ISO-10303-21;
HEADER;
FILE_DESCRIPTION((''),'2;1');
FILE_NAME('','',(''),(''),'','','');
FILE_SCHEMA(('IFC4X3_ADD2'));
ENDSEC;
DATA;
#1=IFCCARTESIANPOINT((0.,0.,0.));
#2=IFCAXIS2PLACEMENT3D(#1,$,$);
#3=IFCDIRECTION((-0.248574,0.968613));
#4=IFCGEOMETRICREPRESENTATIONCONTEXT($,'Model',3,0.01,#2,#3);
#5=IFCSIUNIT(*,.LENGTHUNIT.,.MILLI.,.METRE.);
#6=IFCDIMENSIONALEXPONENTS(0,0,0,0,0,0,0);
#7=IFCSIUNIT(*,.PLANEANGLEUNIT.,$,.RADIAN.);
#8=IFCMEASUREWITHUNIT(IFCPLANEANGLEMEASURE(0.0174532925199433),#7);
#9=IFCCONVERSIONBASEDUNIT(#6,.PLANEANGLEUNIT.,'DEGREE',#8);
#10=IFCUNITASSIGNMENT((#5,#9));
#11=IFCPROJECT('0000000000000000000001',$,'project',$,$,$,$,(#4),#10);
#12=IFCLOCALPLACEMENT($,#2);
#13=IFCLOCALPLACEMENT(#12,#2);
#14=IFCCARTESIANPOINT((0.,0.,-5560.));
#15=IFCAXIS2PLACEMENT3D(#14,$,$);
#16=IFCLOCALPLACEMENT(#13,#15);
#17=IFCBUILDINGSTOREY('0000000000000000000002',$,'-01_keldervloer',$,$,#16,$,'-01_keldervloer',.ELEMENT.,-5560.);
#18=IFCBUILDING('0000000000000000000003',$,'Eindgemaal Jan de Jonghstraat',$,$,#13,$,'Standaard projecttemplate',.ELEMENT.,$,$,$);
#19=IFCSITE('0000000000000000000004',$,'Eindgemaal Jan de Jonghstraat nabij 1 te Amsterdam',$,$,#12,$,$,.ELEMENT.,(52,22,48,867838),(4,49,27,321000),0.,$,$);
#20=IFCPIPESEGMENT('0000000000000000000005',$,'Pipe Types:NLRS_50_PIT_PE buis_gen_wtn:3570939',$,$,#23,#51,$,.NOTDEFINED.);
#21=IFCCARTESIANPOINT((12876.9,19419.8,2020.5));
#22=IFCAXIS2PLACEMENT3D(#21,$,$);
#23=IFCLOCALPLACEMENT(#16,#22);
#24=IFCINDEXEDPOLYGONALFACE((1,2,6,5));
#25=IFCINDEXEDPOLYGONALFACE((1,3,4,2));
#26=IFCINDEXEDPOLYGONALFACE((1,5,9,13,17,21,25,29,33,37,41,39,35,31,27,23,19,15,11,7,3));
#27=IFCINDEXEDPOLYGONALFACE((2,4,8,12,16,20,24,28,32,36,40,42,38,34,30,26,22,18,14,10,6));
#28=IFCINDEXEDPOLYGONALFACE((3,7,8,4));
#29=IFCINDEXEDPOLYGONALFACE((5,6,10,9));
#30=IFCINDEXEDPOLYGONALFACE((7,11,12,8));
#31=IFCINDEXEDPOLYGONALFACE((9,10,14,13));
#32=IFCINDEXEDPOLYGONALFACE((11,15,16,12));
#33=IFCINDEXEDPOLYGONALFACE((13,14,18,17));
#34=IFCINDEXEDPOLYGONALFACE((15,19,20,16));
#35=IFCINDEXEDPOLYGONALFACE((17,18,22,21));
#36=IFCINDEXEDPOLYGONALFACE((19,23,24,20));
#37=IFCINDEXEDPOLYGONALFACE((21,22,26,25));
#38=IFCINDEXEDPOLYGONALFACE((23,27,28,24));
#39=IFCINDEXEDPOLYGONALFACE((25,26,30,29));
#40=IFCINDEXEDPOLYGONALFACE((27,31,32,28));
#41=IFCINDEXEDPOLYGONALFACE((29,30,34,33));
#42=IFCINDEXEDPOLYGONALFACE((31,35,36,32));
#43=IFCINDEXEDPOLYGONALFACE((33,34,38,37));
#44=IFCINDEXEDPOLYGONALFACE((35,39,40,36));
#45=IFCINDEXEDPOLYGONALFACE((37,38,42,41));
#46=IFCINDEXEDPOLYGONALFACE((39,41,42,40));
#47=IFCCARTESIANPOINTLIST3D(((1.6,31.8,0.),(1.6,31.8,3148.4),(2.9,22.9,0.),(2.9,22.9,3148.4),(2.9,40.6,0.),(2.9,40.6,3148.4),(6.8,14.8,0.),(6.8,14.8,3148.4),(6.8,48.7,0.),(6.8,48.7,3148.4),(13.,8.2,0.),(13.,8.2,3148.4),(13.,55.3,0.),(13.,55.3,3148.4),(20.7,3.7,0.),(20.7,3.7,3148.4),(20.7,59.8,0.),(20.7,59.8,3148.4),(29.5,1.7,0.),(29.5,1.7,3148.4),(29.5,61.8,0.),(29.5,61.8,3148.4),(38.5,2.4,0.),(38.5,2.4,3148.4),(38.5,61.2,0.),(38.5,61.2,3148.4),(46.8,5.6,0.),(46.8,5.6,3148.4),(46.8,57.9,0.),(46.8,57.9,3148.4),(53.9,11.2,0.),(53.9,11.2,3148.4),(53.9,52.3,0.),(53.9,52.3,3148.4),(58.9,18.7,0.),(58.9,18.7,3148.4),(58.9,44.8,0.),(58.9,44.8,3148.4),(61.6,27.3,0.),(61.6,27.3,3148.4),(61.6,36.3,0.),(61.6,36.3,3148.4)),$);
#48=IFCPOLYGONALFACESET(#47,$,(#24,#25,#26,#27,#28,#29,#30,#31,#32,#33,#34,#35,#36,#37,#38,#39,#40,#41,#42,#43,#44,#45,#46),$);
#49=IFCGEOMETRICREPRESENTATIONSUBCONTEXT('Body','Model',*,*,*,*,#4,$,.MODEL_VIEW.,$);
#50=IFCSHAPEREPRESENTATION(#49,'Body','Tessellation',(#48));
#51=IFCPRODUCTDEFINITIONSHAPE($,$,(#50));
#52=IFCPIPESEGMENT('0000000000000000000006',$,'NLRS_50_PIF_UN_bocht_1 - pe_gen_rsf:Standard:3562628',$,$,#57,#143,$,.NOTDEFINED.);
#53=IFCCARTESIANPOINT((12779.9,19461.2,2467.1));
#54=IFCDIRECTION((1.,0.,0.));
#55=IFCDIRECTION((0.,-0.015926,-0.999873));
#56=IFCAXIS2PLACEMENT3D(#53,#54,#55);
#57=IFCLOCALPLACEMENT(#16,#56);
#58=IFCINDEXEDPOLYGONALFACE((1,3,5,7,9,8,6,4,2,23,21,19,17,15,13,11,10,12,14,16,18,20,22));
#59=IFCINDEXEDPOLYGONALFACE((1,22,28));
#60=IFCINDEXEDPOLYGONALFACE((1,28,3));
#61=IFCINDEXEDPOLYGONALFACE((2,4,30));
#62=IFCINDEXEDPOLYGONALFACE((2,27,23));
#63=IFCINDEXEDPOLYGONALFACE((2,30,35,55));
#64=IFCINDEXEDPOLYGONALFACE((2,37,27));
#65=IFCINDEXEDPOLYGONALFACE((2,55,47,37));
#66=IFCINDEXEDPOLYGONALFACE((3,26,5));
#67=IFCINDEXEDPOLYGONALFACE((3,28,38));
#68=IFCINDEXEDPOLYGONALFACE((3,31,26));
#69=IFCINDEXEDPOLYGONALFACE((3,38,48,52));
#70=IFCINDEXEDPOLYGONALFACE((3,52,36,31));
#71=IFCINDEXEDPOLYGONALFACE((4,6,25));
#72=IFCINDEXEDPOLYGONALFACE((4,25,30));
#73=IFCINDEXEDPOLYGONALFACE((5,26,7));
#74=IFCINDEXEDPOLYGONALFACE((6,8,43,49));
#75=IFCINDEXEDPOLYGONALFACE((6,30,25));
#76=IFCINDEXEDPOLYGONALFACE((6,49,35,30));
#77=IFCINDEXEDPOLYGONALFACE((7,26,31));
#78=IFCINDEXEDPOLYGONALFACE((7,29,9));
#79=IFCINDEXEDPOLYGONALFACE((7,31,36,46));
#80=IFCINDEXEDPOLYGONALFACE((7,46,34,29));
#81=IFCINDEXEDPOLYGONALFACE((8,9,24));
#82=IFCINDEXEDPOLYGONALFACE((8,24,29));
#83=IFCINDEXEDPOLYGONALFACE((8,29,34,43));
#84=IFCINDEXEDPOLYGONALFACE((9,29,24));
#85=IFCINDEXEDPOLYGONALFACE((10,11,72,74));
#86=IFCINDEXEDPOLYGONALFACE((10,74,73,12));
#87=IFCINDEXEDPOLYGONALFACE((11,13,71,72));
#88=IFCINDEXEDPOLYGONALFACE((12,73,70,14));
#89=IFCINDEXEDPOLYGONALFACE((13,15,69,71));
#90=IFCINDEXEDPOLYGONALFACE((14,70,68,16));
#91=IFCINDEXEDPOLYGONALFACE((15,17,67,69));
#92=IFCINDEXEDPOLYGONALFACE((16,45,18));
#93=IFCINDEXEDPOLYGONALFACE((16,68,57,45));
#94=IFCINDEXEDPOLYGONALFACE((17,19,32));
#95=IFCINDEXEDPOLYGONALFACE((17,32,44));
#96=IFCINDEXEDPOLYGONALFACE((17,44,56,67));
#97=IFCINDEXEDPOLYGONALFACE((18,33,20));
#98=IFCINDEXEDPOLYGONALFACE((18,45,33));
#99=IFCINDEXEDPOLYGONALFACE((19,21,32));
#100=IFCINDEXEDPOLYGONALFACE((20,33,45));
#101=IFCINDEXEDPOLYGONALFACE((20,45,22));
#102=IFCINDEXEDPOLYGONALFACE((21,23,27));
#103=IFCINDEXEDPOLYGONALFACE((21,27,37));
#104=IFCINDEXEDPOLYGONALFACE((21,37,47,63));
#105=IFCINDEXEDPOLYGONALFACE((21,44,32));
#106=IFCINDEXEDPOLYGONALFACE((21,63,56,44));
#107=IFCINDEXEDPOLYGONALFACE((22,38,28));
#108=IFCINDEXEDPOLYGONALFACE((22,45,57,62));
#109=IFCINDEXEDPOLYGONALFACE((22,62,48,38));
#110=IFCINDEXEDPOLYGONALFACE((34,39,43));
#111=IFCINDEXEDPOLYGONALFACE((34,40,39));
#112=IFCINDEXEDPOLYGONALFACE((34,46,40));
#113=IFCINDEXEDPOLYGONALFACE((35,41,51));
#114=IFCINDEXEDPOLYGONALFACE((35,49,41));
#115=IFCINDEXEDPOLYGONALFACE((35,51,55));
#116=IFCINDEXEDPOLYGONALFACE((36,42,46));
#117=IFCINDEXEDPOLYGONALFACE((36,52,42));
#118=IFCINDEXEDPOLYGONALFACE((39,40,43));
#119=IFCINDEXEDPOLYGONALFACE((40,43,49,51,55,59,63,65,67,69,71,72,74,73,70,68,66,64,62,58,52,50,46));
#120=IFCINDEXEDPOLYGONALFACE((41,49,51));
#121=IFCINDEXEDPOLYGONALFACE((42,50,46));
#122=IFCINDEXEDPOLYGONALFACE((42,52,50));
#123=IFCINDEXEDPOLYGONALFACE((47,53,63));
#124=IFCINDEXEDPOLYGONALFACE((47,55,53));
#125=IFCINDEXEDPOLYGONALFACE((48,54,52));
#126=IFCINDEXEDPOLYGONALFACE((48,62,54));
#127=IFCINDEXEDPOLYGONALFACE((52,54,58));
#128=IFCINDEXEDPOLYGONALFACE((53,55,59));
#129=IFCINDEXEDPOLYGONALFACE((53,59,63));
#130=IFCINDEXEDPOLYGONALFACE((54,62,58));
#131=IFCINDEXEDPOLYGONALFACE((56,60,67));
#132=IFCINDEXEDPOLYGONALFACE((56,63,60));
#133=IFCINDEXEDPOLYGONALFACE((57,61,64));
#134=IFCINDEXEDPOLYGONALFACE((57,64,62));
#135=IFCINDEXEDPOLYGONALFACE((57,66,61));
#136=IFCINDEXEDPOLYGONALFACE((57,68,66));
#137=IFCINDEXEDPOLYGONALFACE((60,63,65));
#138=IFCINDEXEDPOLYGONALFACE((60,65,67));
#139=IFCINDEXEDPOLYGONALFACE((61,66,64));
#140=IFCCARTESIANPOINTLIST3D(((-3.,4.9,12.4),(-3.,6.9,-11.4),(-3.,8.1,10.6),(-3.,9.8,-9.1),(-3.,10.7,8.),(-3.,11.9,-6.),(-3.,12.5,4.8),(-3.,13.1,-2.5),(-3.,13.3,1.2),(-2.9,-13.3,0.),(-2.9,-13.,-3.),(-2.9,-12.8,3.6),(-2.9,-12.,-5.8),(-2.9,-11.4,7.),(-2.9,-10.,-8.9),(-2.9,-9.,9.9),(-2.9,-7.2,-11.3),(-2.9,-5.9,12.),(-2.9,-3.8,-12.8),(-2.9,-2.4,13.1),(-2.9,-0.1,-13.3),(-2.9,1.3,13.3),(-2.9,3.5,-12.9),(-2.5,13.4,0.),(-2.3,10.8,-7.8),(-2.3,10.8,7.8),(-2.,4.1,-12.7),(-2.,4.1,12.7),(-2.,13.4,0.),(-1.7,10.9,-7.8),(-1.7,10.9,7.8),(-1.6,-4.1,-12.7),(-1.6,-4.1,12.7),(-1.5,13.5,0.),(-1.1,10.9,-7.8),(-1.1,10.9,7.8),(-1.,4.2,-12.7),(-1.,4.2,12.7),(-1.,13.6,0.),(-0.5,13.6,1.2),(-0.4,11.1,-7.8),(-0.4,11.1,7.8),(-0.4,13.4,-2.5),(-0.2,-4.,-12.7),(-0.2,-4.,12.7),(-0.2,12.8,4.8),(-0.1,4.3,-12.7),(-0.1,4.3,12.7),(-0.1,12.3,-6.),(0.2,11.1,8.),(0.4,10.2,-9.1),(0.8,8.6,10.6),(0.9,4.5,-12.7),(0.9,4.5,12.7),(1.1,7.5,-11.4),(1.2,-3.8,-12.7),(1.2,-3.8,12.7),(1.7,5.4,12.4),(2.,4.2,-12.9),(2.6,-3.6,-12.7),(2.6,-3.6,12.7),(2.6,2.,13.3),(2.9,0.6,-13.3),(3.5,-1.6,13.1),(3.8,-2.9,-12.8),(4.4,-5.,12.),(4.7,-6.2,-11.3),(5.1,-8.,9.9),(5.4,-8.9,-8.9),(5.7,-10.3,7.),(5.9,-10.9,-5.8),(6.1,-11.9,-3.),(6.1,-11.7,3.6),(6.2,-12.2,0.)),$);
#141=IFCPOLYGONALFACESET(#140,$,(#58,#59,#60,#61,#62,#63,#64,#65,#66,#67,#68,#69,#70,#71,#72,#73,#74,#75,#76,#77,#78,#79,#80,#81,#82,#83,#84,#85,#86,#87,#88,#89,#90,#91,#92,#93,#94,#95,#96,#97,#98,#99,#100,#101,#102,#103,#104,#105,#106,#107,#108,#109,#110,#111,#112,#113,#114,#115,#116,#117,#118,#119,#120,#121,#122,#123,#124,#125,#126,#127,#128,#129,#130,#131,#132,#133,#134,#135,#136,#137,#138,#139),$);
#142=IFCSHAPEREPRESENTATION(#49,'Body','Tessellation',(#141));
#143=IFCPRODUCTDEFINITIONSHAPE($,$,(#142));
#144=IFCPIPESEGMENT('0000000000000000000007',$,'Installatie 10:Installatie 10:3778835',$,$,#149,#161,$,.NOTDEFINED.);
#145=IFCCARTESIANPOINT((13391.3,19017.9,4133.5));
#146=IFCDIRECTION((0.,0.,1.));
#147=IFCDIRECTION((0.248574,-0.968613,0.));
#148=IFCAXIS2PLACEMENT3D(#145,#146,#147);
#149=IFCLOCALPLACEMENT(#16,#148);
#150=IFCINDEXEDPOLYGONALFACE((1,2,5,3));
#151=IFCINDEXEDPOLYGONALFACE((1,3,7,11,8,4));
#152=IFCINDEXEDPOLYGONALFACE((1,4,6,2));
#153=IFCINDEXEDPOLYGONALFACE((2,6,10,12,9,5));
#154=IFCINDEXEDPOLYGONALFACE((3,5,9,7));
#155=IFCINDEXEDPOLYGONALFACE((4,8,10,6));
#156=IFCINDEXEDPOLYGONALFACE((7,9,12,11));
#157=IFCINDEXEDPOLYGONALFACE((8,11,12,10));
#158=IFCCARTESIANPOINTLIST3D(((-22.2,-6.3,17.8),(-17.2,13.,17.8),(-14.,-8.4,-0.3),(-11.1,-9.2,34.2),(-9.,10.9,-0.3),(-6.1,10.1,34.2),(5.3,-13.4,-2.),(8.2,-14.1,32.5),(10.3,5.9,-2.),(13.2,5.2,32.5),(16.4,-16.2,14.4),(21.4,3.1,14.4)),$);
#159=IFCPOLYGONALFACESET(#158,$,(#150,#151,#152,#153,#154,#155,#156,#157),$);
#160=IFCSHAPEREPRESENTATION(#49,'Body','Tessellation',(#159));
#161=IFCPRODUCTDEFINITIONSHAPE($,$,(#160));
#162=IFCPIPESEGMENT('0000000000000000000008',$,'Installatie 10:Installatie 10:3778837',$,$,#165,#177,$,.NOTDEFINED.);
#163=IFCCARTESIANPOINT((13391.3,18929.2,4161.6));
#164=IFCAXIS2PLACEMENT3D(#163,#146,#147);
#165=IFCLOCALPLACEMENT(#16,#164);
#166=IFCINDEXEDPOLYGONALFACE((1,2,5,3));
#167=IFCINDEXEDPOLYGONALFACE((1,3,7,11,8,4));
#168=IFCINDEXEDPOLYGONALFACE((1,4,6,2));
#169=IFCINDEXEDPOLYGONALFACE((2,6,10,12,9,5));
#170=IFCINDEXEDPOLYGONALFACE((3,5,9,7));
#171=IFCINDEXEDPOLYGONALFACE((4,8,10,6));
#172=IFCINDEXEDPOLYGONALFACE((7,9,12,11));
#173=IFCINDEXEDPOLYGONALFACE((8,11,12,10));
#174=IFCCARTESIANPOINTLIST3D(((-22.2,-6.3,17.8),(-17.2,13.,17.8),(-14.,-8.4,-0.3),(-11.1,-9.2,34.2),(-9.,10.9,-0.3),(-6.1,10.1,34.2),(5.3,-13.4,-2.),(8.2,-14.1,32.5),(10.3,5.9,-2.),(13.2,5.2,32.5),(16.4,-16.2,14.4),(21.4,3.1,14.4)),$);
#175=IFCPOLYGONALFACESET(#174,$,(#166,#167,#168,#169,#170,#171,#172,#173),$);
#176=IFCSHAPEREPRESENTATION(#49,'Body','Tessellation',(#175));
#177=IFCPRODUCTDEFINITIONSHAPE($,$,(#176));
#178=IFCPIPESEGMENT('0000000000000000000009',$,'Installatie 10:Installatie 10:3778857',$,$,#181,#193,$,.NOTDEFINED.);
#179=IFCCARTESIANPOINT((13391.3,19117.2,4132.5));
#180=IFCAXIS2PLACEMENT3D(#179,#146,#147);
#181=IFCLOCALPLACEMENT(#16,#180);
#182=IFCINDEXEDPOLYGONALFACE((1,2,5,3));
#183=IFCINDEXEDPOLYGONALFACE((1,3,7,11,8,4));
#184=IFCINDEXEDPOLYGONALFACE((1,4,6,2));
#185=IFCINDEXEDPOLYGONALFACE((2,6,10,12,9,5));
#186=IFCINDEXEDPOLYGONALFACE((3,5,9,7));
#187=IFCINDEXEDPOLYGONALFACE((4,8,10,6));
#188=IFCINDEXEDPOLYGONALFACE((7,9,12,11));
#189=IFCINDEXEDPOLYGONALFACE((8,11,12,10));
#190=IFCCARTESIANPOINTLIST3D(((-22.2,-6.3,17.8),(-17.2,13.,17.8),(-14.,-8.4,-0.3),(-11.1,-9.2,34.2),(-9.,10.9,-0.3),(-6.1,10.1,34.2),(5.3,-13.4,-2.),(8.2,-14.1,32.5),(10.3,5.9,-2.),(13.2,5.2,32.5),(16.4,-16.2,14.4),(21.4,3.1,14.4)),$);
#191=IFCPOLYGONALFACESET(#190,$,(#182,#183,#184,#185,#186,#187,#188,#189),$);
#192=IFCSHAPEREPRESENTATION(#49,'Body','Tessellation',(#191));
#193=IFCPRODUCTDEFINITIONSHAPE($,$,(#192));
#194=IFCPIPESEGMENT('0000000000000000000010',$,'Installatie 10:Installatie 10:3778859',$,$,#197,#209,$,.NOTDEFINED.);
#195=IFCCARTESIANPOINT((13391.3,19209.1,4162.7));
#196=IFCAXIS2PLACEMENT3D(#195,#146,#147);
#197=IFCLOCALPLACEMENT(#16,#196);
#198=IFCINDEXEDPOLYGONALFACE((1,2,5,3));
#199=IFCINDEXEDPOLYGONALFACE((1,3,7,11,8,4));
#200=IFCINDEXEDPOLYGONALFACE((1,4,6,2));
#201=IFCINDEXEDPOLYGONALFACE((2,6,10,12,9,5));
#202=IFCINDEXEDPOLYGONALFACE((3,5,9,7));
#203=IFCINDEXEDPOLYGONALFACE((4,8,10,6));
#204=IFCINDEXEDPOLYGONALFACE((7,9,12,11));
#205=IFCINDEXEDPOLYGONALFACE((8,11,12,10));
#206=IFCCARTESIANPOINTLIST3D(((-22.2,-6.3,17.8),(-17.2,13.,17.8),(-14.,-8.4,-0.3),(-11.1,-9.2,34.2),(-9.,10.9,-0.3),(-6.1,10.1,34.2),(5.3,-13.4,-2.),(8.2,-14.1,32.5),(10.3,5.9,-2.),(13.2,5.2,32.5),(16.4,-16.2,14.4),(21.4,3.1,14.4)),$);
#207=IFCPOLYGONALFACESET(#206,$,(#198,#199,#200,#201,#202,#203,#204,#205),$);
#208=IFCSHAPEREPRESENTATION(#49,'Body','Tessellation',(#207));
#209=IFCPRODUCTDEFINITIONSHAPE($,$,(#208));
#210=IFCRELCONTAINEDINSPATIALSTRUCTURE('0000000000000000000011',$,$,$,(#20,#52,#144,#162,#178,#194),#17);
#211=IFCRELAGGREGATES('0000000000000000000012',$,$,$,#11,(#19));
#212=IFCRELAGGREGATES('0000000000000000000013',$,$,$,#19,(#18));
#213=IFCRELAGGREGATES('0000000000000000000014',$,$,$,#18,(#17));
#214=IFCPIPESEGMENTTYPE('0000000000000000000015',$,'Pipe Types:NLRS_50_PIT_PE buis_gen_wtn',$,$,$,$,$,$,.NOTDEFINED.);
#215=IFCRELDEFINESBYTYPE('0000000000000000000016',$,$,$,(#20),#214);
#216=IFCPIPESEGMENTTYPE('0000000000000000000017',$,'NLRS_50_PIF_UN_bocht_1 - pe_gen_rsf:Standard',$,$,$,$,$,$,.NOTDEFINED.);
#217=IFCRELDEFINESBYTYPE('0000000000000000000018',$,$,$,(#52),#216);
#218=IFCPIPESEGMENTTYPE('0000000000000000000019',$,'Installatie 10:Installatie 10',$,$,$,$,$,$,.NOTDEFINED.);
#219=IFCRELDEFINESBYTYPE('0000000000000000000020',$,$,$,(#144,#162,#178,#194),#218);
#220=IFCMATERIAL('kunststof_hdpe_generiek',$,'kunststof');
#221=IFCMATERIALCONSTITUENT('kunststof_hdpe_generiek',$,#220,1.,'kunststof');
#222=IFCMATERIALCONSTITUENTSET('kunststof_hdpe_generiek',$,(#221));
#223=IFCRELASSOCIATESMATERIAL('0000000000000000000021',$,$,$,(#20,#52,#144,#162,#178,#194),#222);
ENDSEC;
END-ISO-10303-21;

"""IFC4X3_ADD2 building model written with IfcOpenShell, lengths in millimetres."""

from ifc_helpers import new_model, entity, si_unit, converted_unit, direction, frame, frame_2d, origin, place, context, subcontext, project, spatial, polyline, circle, outline, extrude, source, transform, mapped, material, constituent, constituent_set, type_object, type_shapes, element, save


model = new_model("IFC4X3_ADD2")

# Units and contexts
model_context = context("Model", 3, precision=0.01, world=origin(), true_north=direction((-0.248574, 0.968613)))
body_context = subcontext(model_context, "Body", "Model", "MODEL_VIEW")
ifc_project = project(units=[si_unit("LENGTHUNIT", "METRE", prefix="MILLI"), converted_unit("PLANEANGLEUNIT", "DEGREE", entity("IfcPlaneAngleMeasure", 0.0174532925199433), si_unit("PLANEANGLEUNIT", "RADIAN"), dimensions=[0, 0, 0, 0, 0, 0, 0])], contexts=[model_context])

# Site, building, storey
site_placement = place(None, origin())
site = spatial("IfcSite", under=ifc_project, at=site_placement, Name="Eindgemaal Jan de Jonghstraat nabij 1 te Amsterdam", CompositionType="ELEMENT", RefLatitude=(52, 22, 48, 867838), RefLongitude=(4, 49, 27, 321000), RefElevation=0.0)
building_placement = place(site_placement, origin())
building = spatial("IfcBuilding", under=site, at=building_placement, Name="Eindgemaal Jan de Jonghstraat", LongName="Standaard projecttemplate", CompositionType="ELEMENT")
storey_placement = place(building_placement, frame((0.0, 0.0, -5560.0)))
storey = spatial("IfcBuildingStorey", under=building, at=storey_placement, Name="-01_keldervloer", LongName="-01_keldervloer", CompositionType="ELEMENT", Elevation=-5560.0)

# Pipe segments
ifc_material_1 = material(Name="kunststof_hdpe_generiek", Category="kunststof")
ifc_constituent_1 = constituent(ifc_material_1, Name="kunststof_hdpe_generiek", Category="kunststof", fraction=1.0)
ifc_constituent_set_1 = constituent_set(constituents=[ifc_constituent_1], Name="kunststof_hdpe_generiek")
pipe_segment_type_1 = type_object("IfcPipeSegmentType", Name="Pipe Types:NLRS_50_PIT_PE buis_gen_wtn", PredefinedType="NOTDEFINED")
pipe_segment_1_placement = place(storey_placement, frame((12876.9, 19419.8, 2020.5)))
element("IfcPipeSegment", 1, at=pipe_segment_1_placement, inside=storey, type_object=pipe_segment_type_1, material=ifc_constituent_set_1, Name="Pipe Types:NLRS_50_PIT_PE buis_gen_wtn:3570939", PredefinedType="NOTDEFINED", context=body_context, shape_type="SweptSolid", body=[
    extrude(circle(Radius=30.2, at=frame_2d((0.0, 0.0), x_axis=(1.0, 0.0))), frame((31.8, 31.8, 0.0), z_axis=(0.0, 0.0, 1.0), x_axis=(-1.0, 0.0, 0.0)), (0.0, 0.0, 1.0), 3148.4),
])
pipe_segment_type_2 = type_object("IfcPipeSegmentType", Name="NLRS_50_PIF_UN_bocht_1 - pe_gen_rsf:Standard", PredefinedType="NOTDEFINED")
trimmed_curve = entity("IfcTrimmedCurve", entity("IfcCircle", entity("IfcAxis2Placement2D", entity("IfcCartesianPoint", [-10.0, 0.0]), entity("IfcDirection", [0.968378, 0.249489])), 10.0), [entity("IfcParameterValue", 345.552699)], [entity("IfcParameterValue", 0.0)], True, "PARAMETER")
shared_shape_1 = source(origin(), body_context, "Body", "AdvancedSweptSolid", [
    entity("IfcSurfaceCurveSweptAreaSolid", entity("IfcCircleProfileDef", "AREA", None, entity("IfcAxis2Placement2D", entity("IfcCartesianPoint", [13.3, 0.0]), entity("IfcDirection", [1.0, 0.0])), 13.3), entity("IfcAxis2Placement3D", entity("IfcCartesianPoint", [-0.5, 13.7, 0.0]), entity("IfcDirection", [0.0, 0.0, -1.0]), entity("IfcDirection", [0.249489, -0.968378, 0.0])), trimmed_curve, entity("IfcParameterValue", 0.0), entity("IfcParameterValue", 14.447301), entity("IfcSurfaceOfLinearExtrusion", entity("IfcArbitraryOpenProfileDef", "CURVE", None, trimmed_curve), entity("IfcAxis2Placement3D", entity("IfcCartesianPoint", [0.0, 0.0, -304.8])), entity("IfcDirection", [0.0, 0.0, 1.0]), 1.0)),
])
type_shapes(pipe_segment_type_2, [shared_shape_1])
pipe_segment_2_placement = place(storey_placement, frame((12779.9, 19461.2, 2467.1), z_axis=(1.0, 0.0, 0.0), x_axis=(0.0, -0.015926, -0.999873)))
element("IfcPipeSegment", 2, at=pipe_segment_2_placement, inside=storey, type_object=pipe_segment_type_2, material=ifc_constituent_set_1, Name="NLRS_50_PIF_UN_bocht_1 - pe_gen_rsf:Standard:3562628", PredefinedType="NOTDEFINED", context=body_context, shape_type="MappedRepresentation", body=[
    mapped(shared_shape_1, transform((0.0, 0.0, 0.0), scale=1.0)),
])

# Pipe segments
pipe_segment_type_3 = type_object("IfcPipeSegmentType", Name="Installatie 10:Installatie 10", PredefinedType="NOTDEFINED")
shared_shape_2 = source(origin(), body_context, "Body", "SweptSolid", [
    extrude(outline(polyline([(-10.0, -17.3), (10.0, -17.3), (20.0, 0.0), (10.0, 17.3), (-10.0, 17.3), (-20.0, 0.0), (-10.0, -17.3)])), frame((-2.9, -11.3, 16.1), z_axis=(0.248574, 0.968613, 0.0), x_axis=(0.409353, -0.105052, -0.906308)), (0.0, 0.0, 1.0), 19.9),
])
type_shapes(pipe_segment_type_3, [shared_shape_2])
for number, where, z_axis, x_axis, name in (
    (3, (13391.3, 19017.9, 4133.5), (0.0, 0.0, 1.0), (0.248574, -0.968613, 0.0), "Installatie 10:Installatie 10:3778835"),
    (4, (13391.3, 18929.2, 4161.6), (0.0, 0.0, 1.0), (0.248574, -0.968613, 0.0), "Installatie 10:Installatie 10:3778837"),
    (5, (13391.3, 19117.2, 4132.5), (0.0, 0.0, 1.0), (0.248574, -0.968613, 0.0), "Installatie 10:Installatie 10:3778857"),
    (6, (13391.3, 19209.1, 4162.7), (0.0, 0.0, 1.0), (0.248574, -0.968613, 0.0), "Installatie 10:Installatie 10:3778859"),
):
    element("IfcPipeSegment", number, at=place(storey_placement, frame(where, z_axis=z_axis, x_axis=x_axis)), inside=storey, type_object=pipe_segment_type_3, material=ifc_constituent_set_1, Name=name, PredefinedType="NOTDEFINED", context=body_context, shape_type="MappedRepresentation", body=[
        mapped(shared_shape_2, transform((0.0, 0.0, 0.0), scale=1.0)),
    ])

save(model, "model.ifc")
